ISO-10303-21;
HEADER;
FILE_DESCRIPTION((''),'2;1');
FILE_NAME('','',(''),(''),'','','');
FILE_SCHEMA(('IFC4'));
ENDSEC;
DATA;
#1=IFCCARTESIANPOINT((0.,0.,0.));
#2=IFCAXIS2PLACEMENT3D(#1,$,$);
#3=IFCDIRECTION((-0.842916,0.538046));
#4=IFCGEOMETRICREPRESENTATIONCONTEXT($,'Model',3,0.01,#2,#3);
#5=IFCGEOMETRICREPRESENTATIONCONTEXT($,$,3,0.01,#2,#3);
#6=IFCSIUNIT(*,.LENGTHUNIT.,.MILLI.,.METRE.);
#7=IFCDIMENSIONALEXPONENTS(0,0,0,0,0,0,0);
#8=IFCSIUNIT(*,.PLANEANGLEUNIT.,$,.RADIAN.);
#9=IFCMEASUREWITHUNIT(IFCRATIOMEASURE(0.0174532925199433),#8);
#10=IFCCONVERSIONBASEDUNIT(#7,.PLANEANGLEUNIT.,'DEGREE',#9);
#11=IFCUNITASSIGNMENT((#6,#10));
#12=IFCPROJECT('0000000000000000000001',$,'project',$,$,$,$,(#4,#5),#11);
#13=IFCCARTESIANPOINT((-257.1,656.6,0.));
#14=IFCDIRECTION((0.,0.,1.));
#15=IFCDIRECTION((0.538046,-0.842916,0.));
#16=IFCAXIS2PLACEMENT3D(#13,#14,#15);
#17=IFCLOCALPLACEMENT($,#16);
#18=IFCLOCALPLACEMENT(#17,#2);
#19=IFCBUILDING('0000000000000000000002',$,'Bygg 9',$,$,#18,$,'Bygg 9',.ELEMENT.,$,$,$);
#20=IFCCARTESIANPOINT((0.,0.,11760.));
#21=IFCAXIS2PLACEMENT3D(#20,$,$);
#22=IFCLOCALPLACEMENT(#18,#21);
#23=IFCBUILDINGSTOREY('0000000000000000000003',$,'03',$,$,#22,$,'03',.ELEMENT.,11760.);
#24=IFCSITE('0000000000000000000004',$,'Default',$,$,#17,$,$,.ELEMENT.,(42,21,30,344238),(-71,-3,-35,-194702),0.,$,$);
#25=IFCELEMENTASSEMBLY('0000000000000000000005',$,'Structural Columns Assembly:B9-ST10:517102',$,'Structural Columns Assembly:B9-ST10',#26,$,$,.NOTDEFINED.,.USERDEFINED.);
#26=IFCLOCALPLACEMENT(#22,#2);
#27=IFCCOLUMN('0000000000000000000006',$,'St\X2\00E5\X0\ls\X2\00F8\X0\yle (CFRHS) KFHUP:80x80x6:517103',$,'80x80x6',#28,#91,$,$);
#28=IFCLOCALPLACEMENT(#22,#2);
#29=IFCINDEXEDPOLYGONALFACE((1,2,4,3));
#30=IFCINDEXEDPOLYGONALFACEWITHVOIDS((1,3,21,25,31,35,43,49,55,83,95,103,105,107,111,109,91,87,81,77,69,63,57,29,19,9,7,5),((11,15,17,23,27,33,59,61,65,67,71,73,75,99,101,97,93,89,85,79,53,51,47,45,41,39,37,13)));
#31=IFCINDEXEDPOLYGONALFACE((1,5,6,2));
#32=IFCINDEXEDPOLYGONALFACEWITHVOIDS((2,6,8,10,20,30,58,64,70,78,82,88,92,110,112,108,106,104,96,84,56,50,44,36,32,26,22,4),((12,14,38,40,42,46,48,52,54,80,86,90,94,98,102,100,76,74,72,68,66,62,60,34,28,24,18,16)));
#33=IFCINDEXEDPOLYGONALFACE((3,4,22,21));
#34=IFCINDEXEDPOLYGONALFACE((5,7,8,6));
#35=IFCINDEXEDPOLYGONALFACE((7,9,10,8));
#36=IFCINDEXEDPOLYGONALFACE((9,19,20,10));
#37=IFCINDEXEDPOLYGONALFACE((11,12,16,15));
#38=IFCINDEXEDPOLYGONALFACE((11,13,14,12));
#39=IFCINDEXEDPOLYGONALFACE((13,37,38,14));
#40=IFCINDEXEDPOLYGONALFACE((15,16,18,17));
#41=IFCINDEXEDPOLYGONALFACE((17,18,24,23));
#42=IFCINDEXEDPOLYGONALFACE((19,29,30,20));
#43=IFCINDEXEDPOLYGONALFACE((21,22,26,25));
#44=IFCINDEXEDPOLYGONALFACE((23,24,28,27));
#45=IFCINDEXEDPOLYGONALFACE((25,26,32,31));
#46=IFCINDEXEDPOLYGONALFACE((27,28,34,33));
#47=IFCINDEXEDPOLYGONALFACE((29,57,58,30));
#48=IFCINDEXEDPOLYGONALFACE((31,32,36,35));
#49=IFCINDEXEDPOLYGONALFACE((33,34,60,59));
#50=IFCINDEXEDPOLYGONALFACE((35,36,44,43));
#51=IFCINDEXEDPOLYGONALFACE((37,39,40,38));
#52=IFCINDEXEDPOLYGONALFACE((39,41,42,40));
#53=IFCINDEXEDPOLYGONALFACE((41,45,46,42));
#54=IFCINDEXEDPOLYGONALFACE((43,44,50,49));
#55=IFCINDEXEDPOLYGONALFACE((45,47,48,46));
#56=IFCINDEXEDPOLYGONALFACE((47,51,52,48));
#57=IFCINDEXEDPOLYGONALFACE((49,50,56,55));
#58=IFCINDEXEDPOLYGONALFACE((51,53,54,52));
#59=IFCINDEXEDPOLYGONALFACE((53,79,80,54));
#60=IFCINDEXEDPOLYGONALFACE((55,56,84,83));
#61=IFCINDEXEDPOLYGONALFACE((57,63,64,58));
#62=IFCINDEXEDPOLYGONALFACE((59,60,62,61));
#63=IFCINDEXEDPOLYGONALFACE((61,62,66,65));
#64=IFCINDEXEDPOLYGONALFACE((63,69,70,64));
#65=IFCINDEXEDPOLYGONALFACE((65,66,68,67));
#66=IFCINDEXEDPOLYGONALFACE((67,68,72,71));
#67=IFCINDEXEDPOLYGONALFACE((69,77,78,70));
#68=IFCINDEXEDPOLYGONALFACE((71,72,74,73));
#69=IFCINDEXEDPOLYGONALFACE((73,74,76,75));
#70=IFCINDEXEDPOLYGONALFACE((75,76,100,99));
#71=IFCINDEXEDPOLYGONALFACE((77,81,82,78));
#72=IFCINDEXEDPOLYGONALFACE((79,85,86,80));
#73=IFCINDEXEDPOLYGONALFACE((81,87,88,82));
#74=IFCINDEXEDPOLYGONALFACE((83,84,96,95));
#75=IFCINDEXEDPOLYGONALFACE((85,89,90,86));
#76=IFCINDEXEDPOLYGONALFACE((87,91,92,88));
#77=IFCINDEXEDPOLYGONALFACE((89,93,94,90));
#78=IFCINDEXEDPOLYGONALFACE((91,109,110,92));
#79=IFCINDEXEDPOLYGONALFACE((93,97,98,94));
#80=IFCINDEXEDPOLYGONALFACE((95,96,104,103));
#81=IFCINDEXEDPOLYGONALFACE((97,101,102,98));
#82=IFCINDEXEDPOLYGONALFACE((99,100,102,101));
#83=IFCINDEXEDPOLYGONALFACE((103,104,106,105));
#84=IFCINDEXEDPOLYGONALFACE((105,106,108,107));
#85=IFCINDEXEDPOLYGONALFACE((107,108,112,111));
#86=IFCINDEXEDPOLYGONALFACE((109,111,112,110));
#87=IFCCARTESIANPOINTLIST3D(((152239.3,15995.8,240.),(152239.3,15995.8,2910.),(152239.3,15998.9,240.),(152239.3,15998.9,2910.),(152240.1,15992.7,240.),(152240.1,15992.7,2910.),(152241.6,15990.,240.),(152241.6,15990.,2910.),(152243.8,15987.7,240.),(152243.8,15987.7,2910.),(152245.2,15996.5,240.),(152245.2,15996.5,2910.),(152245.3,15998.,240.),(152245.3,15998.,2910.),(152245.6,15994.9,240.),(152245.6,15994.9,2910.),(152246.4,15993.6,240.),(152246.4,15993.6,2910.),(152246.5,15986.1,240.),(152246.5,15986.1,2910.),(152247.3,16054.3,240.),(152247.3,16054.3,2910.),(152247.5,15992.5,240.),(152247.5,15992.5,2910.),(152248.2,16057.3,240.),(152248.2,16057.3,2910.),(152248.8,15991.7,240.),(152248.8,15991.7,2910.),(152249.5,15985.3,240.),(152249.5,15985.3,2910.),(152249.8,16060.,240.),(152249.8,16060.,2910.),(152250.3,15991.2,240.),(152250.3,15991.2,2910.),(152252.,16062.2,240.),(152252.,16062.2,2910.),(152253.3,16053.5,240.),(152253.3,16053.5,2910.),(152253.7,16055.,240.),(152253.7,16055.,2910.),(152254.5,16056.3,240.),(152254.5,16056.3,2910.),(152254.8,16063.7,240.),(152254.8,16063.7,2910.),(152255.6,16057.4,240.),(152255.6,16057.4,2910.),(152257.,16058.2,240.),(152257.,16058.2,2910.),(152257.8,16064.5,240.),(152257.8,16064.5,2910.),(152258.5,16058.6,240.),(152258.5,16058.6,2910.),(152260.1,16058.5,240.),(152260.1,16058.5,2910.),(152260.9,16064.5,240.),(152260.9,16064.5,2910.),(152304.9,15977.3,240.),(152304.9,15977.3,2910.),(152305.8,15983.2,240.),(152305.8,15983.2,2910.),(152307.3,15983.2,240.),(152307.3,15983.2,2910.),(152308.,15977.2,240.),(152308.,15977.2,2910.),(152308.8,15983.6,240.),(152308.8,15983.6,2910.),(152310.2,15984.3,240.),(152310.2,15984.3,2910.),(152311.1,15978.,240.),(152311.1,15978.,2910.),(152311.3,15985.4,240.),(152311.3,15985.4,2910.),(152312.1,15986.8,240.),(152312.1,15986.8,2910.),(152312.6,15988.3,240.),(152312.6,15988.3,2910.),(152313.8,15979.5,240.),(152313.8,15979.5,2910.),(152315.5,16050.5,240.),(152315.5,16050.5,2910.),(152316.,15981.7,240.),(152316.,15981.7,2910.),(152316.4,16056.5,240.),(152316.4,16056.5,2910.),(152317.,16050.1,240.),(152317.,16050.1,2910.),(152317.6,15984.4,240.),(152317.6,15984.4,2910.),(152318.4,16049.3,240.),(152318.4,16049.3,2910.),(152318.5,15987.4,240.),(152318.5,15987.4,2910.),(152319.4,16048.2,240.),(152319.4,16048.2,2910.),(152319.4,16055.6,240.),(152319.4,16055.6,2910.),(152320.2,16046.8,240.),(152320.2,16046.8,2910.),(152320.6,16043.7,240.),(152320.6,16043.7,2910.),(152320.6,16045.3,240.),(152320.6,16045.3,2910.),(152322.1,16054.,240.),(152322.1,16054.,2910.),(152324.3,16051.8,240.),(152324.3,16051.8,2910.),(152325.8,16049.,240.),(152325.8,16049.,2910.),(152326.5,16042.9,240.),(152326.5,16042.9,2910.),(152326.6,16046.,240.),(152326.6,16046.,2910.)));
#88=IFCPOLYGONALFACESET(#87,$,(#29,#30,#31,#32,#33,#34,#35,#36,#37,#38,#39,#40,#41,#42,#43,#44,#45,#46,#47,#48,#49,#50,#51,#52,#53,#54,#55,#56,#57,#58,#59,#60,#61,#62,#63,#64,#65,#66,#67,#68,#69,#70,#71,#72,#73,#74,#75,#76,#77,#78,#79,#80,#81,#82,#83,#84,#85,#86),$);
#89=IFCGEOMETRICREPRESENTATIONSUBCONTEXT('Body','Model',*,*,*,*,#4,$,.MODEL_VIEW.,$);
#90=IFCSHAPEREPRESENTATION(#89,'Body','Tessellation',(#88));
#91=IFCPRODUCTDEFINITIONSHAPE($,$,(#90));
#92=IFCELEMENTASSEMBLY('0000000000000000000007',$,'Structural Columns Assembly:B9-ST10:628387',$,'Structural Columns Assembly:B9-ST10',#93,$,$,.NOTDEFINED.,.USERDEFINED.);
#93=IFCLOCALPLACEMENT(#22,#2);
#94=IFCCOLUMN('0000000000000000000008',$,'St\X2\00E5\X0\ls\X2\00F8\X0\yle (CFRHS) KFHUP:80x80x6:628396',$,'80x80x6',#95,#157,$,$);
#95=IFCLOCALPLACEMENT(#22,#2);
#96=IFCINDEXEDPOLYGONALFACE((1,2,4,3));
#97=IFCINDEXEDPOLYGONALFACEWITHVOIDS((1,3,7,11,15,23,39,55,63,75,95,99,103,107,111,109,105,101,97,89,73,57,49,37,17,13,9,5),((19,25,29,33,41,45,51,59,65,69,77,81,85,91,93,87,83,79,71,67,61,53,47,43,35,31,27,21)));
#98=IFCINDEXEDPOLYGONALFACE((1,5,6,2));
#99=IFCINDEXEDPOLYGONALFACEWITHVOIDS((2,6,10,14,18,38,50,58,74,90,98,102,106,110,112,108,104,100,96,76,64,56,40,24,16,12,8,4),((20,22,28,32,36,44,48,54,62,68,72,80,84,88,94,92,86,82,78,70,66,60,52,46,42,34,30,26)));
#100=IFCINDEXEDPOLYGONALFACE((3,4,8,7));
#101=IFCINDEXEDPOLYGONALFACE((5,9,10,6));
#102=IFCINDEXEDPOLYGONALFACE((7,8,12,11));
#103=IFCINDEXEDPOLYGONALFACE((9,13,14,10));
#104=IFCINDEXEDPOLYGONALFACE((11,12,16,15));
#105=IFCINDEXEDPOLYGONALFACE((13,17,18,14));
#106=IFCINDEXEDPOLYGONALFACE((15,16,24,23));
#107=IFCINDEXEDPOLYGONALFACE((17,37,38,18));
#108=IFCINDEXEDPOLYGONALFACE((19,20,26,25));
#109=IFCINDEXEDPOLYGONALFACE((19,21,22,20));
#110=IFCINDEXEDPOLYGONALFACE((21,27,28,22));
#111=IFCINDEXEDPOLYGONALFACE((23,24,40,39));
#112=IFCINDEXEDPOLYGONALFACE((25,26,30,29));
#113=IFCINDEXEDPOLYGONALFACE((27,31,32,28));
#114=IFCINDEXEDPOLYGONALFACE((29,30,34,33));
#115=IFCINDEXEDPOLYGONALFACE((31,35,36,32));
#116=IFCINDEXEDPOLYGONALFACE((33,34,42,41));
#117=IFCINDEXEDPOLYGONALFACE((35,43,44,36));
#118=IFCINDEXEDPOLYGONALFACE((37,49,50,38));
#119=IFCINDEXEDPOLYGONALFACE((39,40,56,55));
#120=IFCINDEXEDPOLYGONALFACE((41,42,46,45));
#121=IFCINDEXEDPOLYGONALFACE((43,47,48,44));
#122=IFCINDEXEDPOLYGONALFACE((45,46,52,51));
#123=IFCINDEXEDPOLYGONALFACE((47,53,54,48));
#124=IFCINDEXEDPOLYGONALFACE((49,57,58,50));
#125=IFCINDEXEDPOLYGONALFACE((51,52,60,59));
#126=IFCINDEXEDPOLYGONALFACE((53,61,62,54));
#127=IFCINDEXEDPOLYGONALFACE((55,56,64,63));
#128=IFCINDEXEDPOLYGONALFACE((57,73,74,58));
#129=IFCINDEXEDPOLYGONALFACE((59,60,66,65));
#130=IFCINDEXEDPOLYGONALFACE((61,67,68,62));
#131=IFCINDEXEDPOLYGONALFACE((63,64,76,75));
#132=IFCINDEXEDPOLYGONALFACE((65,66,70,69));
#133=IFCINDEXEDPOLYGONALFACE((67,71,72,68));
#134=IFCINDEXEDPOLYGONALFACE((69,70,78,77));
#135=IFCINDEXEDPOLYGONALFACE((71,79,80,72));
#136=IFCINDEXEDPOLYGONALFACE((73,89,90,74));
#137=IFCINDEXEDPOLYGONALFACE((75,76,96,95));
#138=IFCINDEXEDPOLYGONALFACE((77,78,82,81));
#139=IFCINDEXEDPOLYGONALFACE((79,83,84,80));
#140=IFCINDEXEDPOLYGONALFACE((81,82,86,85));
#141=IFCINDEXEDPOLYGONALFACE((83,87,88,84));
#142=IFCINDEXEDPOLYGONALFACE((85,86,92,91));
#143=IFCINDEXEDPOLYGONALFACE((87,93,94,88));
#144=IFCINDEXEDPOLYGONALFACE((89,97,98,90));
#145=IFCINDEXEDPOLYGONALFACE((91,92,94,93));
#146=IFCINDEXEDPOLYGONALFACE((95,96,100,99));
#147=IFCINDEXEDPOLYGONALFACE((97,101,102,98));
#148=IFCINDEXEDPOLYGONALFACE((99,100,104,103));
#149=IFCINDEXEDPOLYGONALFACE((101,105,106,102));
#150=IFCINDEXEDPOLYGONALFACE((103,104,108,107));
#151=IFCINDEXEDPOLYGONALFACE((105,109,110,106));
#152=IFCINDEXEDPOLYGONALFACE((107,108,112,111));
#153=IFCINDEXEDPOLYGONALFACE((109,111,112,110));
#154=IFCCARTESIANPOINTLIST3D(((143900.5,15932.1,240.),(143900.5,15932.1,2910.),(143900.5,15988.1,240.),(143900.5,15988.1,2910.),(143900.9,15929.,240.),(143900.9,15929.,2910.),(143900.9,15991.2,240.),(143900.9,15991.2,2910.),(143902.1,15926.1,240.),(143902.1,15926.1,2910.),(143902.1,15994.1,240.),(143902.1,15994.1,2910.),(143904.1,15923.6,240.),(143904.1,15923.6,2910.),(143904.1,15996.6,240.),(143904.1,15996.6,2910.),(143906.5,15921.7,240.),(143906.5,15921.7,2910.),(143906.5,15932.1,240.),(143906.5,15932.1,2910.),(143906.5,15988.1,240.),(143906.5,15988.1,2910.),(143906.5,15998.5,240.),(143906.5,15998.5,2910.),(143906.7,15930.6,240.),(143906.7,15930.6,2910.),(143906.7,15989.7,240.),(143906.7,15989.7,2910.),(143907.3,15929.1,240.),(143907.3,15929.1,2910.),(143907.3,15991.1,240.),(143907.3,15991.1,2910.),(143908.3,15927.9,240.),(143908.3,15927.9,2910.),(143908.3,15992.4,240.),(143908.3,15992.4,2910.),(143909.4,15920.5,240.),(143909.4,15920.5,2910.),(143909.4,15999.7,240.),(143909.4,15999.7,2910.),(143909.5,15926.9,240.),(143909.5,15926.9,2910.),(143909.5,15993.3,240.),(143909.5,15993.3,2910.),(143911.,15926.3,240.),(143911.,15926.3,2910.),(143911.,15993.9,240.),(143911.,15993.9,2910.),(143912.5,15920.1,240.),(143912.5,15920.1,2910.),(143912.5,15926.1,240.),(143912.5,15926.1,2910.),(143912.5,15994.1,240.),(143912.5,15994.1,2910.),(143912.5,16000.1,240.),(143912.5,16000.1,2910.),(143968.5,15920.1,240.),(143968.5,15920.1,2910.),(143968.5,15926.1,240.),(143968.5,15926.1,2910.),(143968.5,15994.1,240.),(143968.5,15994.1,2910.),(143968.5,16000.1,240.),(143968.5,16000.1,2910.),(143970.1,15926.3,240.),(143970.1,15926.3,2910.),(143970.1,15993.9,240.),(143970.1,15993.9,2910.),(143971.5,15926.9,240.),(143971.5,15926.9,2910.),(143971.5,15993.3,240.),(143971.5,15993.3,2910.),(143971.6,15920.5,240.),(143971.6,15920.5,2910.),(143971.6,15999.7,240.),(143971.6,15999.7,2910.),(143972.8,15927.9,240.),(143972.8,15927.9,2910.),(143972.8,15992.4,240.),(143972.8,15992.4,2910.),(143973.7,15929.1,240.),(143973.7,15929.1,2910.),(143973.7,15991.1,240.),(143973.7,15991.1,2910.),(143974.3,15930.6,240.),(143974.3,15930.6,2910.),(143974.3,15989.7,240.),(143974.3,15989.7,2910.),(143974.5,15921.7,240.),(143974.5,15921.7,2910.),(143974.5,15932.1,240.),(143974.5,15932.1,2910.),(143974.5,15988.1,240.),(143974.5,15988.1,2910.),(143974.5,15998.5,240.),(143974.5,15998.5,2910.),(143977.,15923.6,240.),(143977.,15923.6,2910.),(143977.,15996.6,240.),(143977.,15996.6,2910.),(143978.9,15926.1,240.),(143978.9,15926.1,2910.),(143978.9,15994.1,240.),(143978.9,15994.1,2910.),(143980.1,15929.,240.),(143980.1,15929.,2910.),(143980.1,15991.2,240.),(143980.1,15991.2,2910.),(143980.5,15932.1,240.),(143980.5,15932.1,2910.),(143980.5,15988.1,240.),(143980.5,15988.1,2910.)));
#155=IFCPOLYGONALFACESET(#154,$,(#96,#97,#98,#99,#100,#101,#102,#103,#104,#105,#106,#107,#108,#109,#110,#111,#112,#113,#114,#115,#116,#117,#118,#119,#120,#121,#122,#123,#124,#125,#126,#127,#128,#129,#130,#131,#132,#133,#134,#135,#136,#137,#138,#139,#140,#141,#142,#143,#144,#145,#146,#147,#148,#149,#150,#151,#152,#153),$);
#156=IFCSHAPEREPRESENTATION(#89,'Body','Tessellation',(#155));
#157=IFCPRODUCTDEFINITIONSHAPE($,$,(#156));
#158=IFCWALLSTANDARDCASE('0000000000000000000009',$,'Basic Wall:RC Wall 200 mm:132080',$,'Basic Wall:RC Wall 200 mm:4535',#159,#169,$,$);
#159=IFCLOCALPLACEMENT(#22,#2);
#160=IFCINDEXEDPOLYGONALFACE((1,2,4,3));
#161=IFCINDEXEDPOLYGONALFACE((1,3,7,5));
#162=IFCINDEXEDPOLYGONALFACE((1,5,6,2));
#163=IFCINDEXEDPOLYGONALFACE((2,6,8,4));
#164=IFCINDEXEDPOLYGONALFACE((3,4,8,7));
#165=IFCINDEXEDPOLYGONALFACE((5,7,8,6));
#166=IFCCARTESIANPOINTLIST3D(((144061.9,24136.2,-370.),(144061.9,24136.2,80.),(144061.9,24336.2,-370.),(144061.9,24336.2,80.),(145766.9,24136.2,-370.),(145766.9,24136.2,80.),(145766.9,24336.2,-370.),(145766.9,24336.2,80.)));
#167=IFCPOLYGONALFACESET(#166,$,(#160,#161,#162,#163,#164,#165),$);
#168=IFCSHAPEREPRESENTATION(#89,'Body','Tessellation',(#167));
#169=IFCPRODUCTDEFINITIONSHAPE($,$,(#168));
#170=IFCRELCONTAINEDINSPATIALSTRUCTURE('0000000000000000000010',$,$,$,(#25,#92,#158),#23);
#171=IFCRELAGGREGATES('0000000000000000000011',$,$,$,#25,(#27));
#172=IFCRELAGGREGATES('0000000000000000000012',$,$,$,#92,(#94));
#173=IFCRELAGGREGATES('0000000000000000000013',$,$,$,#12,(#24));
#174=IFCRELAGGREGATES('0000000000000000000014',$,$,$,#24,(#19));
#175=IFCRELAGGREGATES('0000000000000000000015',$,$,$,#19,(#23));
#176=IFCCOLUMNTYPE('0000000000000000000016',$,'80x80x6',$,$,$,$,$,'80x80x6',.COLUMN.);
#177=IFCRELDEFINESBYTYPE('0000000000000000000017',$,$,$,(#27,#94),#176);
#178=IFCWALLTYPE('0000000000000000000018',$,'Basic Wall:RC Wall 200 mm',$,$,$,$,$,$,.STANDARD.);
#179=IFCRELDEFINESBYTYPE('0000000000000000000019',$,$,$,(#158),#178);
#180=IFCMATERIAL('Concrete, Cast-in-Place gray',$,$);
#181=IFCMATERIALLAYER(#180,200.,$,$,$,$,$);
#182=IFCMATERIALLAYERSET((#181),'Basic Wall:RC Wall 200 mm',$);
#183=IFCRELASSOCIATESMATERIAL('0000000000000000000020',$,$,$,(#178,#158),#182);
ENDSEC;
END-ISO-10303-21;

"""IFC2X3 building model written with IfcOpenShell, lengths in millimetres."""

from ifc_helpers import new_model, entity, si_unit, converted_unit, direction, frame, frame_2d, origin, place, context, subcontext, project, spatial, polyline, circle_curve, parameter, trimmed, segment, composite_curve, rectangle, outline, extrude, source, transform, mapped, material, layer, layer_set, layer_usage, type_object, type_shapes, element, aggregate, save


model = new_model("IFC2X3")

# Units and contexts
model_context = context("Model", 3, precision=0.01, world=origin(), true_north=direction((-0.842916, 0.538046)))
context_of_model = context(None, 3, precision=0.01, world=origin(), true_north=direction((-0.842916, 0.538046)))
body_context = subcontext(model_context, "Body", "Model", "MODEL_VIEW")
ifc_project = project(units=[si_unit("LENGTHUNIT", "METRE", prefix="MILLI"), converted_unit("PLANEANGLEUNIT", "DEGREE", entity("IfcRatioMeasure", 0.0174532925199433), si_unit("PLANEANGLEUNIT", "RADIAN"), dimensions=[0, 0, 0, 0, 0, 0, 0])], contexts=[model_context, context_of_model])

# Site, building, storey
site_placement = place(None, frame((-257.1, 656.6, 0.0), z_axis=(0.0, 0.0, 1.0), x_axis=(0.538046, -0.842916, 0.0)))
site = spatial("IfcSite", under=ifc_project, at=site_placement, Name="Default", CompositionType="ELEMENT", RefLatitude=(42, 21, 30, 344238), RefLongitude=(-71, -3, -35, -194702), RefElevation=0.0)
building_placement = place(site_placement, origin())
building = spatial("IfcBuilding", under=site, at=building_placement, Name="Bygg 9", LongName="Bygg 9", CompositionType="ELEMENT")
storey_placement = place(building_placement, frame((0.0, 0.0, 11760.0)))
storey = spatial("IfcBuildingStorey", under=building, at=storey_placement, Name="03", LongName="03", CompositionType="ELEMENT", Elevation=11760.0)

# Element assemblies, columns
assembly_1_placement = place(storey_placement, origin())
assembly_1 = element("IfcElementAssembly", 1, at=assembly_1_placement, inside=storey, Name="Structural Columns Assembly:B9-ST10:517102", ObjectType="Structural Columns Assembly:B9-ST10", AssemblyPlace="NOTDEFINED", PredefinedType="USERDEFINED")
column_type_1 = type_object("IfcColumnType", Name="80x80x6", ElementType="80x80x6", PredefinedType="COLUMN")
shared_shape_1 = source(origin(), body_context, "Body", "SweptSolid", [
    extrude(outline(composite_curve([segment(trimmed(circle_curve(frame_2d((-28.0, 28.0), x_axis=(1.0, 0.0)), 12.0), [parameter(90.0)], [parameter(180.0)], True, "PARAMETER"), True, "CONTINUOUS"), segment(polyline([(-40.0, 28.0), (-40.0, -28.0)]), True, "CONTINUOUS"), segment(trimmed(circle_curve(frame_2d((-28.0, -28.0), x_axis=(1.0, 0.0)), 12.0), [parameter(180.0)], [parameter(270.0)], True, "PARAMETER"), True, "CONTINUOUS"), segment(polyline([(-28.0, -40.0), (28.0, -40.0)]), True, "CONTINUOUS"), segment(trimmed(circle_curve(frame_2d((28.0, -28.0), x_axis=(1.0, 0.0)), 12.0), [parameter(270.0)], [parameter(0.0)], True, "PARAMETER"), True, "CONTINUOUS"), segment(polyline([(40.0, -28.0), (40.0, 28.0)]), True, "CONTINUOUS"), segment(trimmed(circle_curve(frame_2d((28.0, 28.0), x_axis=(1.0, 0.0)), 12.0), [parameter(0.0)], [parameter(90.0)], True, "PARAMETER"), True, "CONTINUOUS"), segment(polyline([(28.0, 40.0), (-28.0, 40.0)]), True, "CONTINUOUS")], self_intersect=False), holes=[composite_curve([segment(polyline([(-28.0, 34.0), (28.0, 34.0)]), True, "CONTINUOUS"), segment(trimmed(circle_curve(frame_2d((28.0, 28.0), x_axis=(1.0, 0.0)), 6.0), [parameter(360.0)], [parameter(90.0)], True, "PARAMETER"), False, "CONTINUOUS"), segment(polyline([(34.0, 28.0), (34.0, -28.0)]), True, "CONTINUOUS"), segment(trimmed(circle_curve(frame_2d((28.0, -28.0), x_axis=(1.0, 0.0)), 6.0), [parameter(270.0)], [parameter(360.0)], True, "PARAMETER"), False, "CONTINUOUS"), segment(polyline([(28.0, -34.0), (-28.0, -34.0)]), True, "CONTINUOUS"), segment(trimmed(circle_curve(frame_2d((-28.0, -28.0), x_axis=(1.0, 0.0)), 6.0), [parameter(180.0)], [parameter(270.0)], True, "PARAMETER"), False, "CONTINUOUS"), segment(polyline([(-34.0, -28.0), (-34.0, 28.0)]), True, "CONTINUOUS"), segment(trimmed(circle_curve(frame_2d((-28.0, 28.0), x_axis=(1.0, 0.0)), 6.0), [parameter(90.0)], [parameter(180.0)], True, "PARAMETER"), False, "CONTINUOUS")], self_intersect=False)]), frame((41.6, 41.6, 0.0), z_axis=(0.0, 0.0, 1.0), x_axis=(-1.0, 0.0, 0.0)), (0.0, 0.0, 1.0), 2670.0),
])
type_shapes(column_type_1, [shared_shape_1])
column_1_placement = place(assembly_1_placement, frame((152330.0, 16056.1, 240.0), z_axis=(0.0, 0.0, 1.0), x_axis=(-0.989691, 0.143216, 0.0)))
column_1 = element("IfcColumn", 2, at=column_1_placement, type_object=column_type_1, Name="Stålsøyle (CFRHS) KFHUP:80x80x6:517103", ObjectType="80x80x6", context=body_context, shape_type="MappedRepresentation", body=[
    mapped(shared_shape_1, transform((0.0, 0.0, 0.0), scale=1.0)),
])
assembly_2_placement = place(storey_placement, origin())
assembly_2 = element("IfcElementAssembly", 3, at=assembly_2_placement, inside=storey, Name="Structural Columns Assembly:B9-ST10:628387", ObjectType="Structural Columns Assembly:B9-ST10", AssemblyPlace="NOTDEFINED", PredefinedType="USERDEFINED")
column_2_placement = place(assembly_2_placement, frame((143982.1, 15918.5, 240.0), z_axis=(0.0, 0.0, 1.0), x_axis=(0.0, 1.0, 0.0)))
column_2 = element("IfcColumn", 4, at=column_2_placement, type_object=column_type_1, Name="Stålsøyle (CFRHS) KFHUP:80x80x6:628396", ObjectType="80x80x6", context=body_context, shape_type="MappedRepresentation", body=[
    mapped(shared_shape_1, transform((0.0, 0.0, 0.0), scale=1.0)),
])

# Shared definitions
ifc_material_1 = material(Name="Concrete, Cast-in-Place gray")

# Wall
ifc_layer_1 = layer(ifc_material_1, 200.0)
ifc_layer_set_1 = layer_set([ifc_layer_1], Name="Basic Wall:RC Wall 200 mm")
ifc_layer_usage_1 = layer_usage(ifc_layer_set_1, "AXIS2", "NEGATIVE", 100.0)
wall_type = type_object("IfcWallType", Name="Basic Wall:RC Wall 200 mm", PredefinedType="STANDARD", material=ifc_layer_set_1)
wall_placement = place(storey_placement, frame((144061.9, 24236.2, -370.0)))
element("IfcWallStandardCase", 5, at=wall_placement, inside=storey, type_object=wall_type, material=ifc_layer_usage_1, Name="Basic Wall:RC Wall 200 mm:132080", ObjectType="Basic Wall:RC Wall 200 mm:4535", context=body_context, shape_type="SweptSolid", body=[
    extrude(rectangle(XDim=1705.0, YDim=200.0, at=frame_2d((852.5, 0.0), x_axis=(-1.0, 0.0))), origin(), (0.0, 0.0, 1.0), 450.0),
])

aggregate(assembly_1, [column_1])
aggregate(assembly_2, [column_2])

save(model, "model.ifc")
